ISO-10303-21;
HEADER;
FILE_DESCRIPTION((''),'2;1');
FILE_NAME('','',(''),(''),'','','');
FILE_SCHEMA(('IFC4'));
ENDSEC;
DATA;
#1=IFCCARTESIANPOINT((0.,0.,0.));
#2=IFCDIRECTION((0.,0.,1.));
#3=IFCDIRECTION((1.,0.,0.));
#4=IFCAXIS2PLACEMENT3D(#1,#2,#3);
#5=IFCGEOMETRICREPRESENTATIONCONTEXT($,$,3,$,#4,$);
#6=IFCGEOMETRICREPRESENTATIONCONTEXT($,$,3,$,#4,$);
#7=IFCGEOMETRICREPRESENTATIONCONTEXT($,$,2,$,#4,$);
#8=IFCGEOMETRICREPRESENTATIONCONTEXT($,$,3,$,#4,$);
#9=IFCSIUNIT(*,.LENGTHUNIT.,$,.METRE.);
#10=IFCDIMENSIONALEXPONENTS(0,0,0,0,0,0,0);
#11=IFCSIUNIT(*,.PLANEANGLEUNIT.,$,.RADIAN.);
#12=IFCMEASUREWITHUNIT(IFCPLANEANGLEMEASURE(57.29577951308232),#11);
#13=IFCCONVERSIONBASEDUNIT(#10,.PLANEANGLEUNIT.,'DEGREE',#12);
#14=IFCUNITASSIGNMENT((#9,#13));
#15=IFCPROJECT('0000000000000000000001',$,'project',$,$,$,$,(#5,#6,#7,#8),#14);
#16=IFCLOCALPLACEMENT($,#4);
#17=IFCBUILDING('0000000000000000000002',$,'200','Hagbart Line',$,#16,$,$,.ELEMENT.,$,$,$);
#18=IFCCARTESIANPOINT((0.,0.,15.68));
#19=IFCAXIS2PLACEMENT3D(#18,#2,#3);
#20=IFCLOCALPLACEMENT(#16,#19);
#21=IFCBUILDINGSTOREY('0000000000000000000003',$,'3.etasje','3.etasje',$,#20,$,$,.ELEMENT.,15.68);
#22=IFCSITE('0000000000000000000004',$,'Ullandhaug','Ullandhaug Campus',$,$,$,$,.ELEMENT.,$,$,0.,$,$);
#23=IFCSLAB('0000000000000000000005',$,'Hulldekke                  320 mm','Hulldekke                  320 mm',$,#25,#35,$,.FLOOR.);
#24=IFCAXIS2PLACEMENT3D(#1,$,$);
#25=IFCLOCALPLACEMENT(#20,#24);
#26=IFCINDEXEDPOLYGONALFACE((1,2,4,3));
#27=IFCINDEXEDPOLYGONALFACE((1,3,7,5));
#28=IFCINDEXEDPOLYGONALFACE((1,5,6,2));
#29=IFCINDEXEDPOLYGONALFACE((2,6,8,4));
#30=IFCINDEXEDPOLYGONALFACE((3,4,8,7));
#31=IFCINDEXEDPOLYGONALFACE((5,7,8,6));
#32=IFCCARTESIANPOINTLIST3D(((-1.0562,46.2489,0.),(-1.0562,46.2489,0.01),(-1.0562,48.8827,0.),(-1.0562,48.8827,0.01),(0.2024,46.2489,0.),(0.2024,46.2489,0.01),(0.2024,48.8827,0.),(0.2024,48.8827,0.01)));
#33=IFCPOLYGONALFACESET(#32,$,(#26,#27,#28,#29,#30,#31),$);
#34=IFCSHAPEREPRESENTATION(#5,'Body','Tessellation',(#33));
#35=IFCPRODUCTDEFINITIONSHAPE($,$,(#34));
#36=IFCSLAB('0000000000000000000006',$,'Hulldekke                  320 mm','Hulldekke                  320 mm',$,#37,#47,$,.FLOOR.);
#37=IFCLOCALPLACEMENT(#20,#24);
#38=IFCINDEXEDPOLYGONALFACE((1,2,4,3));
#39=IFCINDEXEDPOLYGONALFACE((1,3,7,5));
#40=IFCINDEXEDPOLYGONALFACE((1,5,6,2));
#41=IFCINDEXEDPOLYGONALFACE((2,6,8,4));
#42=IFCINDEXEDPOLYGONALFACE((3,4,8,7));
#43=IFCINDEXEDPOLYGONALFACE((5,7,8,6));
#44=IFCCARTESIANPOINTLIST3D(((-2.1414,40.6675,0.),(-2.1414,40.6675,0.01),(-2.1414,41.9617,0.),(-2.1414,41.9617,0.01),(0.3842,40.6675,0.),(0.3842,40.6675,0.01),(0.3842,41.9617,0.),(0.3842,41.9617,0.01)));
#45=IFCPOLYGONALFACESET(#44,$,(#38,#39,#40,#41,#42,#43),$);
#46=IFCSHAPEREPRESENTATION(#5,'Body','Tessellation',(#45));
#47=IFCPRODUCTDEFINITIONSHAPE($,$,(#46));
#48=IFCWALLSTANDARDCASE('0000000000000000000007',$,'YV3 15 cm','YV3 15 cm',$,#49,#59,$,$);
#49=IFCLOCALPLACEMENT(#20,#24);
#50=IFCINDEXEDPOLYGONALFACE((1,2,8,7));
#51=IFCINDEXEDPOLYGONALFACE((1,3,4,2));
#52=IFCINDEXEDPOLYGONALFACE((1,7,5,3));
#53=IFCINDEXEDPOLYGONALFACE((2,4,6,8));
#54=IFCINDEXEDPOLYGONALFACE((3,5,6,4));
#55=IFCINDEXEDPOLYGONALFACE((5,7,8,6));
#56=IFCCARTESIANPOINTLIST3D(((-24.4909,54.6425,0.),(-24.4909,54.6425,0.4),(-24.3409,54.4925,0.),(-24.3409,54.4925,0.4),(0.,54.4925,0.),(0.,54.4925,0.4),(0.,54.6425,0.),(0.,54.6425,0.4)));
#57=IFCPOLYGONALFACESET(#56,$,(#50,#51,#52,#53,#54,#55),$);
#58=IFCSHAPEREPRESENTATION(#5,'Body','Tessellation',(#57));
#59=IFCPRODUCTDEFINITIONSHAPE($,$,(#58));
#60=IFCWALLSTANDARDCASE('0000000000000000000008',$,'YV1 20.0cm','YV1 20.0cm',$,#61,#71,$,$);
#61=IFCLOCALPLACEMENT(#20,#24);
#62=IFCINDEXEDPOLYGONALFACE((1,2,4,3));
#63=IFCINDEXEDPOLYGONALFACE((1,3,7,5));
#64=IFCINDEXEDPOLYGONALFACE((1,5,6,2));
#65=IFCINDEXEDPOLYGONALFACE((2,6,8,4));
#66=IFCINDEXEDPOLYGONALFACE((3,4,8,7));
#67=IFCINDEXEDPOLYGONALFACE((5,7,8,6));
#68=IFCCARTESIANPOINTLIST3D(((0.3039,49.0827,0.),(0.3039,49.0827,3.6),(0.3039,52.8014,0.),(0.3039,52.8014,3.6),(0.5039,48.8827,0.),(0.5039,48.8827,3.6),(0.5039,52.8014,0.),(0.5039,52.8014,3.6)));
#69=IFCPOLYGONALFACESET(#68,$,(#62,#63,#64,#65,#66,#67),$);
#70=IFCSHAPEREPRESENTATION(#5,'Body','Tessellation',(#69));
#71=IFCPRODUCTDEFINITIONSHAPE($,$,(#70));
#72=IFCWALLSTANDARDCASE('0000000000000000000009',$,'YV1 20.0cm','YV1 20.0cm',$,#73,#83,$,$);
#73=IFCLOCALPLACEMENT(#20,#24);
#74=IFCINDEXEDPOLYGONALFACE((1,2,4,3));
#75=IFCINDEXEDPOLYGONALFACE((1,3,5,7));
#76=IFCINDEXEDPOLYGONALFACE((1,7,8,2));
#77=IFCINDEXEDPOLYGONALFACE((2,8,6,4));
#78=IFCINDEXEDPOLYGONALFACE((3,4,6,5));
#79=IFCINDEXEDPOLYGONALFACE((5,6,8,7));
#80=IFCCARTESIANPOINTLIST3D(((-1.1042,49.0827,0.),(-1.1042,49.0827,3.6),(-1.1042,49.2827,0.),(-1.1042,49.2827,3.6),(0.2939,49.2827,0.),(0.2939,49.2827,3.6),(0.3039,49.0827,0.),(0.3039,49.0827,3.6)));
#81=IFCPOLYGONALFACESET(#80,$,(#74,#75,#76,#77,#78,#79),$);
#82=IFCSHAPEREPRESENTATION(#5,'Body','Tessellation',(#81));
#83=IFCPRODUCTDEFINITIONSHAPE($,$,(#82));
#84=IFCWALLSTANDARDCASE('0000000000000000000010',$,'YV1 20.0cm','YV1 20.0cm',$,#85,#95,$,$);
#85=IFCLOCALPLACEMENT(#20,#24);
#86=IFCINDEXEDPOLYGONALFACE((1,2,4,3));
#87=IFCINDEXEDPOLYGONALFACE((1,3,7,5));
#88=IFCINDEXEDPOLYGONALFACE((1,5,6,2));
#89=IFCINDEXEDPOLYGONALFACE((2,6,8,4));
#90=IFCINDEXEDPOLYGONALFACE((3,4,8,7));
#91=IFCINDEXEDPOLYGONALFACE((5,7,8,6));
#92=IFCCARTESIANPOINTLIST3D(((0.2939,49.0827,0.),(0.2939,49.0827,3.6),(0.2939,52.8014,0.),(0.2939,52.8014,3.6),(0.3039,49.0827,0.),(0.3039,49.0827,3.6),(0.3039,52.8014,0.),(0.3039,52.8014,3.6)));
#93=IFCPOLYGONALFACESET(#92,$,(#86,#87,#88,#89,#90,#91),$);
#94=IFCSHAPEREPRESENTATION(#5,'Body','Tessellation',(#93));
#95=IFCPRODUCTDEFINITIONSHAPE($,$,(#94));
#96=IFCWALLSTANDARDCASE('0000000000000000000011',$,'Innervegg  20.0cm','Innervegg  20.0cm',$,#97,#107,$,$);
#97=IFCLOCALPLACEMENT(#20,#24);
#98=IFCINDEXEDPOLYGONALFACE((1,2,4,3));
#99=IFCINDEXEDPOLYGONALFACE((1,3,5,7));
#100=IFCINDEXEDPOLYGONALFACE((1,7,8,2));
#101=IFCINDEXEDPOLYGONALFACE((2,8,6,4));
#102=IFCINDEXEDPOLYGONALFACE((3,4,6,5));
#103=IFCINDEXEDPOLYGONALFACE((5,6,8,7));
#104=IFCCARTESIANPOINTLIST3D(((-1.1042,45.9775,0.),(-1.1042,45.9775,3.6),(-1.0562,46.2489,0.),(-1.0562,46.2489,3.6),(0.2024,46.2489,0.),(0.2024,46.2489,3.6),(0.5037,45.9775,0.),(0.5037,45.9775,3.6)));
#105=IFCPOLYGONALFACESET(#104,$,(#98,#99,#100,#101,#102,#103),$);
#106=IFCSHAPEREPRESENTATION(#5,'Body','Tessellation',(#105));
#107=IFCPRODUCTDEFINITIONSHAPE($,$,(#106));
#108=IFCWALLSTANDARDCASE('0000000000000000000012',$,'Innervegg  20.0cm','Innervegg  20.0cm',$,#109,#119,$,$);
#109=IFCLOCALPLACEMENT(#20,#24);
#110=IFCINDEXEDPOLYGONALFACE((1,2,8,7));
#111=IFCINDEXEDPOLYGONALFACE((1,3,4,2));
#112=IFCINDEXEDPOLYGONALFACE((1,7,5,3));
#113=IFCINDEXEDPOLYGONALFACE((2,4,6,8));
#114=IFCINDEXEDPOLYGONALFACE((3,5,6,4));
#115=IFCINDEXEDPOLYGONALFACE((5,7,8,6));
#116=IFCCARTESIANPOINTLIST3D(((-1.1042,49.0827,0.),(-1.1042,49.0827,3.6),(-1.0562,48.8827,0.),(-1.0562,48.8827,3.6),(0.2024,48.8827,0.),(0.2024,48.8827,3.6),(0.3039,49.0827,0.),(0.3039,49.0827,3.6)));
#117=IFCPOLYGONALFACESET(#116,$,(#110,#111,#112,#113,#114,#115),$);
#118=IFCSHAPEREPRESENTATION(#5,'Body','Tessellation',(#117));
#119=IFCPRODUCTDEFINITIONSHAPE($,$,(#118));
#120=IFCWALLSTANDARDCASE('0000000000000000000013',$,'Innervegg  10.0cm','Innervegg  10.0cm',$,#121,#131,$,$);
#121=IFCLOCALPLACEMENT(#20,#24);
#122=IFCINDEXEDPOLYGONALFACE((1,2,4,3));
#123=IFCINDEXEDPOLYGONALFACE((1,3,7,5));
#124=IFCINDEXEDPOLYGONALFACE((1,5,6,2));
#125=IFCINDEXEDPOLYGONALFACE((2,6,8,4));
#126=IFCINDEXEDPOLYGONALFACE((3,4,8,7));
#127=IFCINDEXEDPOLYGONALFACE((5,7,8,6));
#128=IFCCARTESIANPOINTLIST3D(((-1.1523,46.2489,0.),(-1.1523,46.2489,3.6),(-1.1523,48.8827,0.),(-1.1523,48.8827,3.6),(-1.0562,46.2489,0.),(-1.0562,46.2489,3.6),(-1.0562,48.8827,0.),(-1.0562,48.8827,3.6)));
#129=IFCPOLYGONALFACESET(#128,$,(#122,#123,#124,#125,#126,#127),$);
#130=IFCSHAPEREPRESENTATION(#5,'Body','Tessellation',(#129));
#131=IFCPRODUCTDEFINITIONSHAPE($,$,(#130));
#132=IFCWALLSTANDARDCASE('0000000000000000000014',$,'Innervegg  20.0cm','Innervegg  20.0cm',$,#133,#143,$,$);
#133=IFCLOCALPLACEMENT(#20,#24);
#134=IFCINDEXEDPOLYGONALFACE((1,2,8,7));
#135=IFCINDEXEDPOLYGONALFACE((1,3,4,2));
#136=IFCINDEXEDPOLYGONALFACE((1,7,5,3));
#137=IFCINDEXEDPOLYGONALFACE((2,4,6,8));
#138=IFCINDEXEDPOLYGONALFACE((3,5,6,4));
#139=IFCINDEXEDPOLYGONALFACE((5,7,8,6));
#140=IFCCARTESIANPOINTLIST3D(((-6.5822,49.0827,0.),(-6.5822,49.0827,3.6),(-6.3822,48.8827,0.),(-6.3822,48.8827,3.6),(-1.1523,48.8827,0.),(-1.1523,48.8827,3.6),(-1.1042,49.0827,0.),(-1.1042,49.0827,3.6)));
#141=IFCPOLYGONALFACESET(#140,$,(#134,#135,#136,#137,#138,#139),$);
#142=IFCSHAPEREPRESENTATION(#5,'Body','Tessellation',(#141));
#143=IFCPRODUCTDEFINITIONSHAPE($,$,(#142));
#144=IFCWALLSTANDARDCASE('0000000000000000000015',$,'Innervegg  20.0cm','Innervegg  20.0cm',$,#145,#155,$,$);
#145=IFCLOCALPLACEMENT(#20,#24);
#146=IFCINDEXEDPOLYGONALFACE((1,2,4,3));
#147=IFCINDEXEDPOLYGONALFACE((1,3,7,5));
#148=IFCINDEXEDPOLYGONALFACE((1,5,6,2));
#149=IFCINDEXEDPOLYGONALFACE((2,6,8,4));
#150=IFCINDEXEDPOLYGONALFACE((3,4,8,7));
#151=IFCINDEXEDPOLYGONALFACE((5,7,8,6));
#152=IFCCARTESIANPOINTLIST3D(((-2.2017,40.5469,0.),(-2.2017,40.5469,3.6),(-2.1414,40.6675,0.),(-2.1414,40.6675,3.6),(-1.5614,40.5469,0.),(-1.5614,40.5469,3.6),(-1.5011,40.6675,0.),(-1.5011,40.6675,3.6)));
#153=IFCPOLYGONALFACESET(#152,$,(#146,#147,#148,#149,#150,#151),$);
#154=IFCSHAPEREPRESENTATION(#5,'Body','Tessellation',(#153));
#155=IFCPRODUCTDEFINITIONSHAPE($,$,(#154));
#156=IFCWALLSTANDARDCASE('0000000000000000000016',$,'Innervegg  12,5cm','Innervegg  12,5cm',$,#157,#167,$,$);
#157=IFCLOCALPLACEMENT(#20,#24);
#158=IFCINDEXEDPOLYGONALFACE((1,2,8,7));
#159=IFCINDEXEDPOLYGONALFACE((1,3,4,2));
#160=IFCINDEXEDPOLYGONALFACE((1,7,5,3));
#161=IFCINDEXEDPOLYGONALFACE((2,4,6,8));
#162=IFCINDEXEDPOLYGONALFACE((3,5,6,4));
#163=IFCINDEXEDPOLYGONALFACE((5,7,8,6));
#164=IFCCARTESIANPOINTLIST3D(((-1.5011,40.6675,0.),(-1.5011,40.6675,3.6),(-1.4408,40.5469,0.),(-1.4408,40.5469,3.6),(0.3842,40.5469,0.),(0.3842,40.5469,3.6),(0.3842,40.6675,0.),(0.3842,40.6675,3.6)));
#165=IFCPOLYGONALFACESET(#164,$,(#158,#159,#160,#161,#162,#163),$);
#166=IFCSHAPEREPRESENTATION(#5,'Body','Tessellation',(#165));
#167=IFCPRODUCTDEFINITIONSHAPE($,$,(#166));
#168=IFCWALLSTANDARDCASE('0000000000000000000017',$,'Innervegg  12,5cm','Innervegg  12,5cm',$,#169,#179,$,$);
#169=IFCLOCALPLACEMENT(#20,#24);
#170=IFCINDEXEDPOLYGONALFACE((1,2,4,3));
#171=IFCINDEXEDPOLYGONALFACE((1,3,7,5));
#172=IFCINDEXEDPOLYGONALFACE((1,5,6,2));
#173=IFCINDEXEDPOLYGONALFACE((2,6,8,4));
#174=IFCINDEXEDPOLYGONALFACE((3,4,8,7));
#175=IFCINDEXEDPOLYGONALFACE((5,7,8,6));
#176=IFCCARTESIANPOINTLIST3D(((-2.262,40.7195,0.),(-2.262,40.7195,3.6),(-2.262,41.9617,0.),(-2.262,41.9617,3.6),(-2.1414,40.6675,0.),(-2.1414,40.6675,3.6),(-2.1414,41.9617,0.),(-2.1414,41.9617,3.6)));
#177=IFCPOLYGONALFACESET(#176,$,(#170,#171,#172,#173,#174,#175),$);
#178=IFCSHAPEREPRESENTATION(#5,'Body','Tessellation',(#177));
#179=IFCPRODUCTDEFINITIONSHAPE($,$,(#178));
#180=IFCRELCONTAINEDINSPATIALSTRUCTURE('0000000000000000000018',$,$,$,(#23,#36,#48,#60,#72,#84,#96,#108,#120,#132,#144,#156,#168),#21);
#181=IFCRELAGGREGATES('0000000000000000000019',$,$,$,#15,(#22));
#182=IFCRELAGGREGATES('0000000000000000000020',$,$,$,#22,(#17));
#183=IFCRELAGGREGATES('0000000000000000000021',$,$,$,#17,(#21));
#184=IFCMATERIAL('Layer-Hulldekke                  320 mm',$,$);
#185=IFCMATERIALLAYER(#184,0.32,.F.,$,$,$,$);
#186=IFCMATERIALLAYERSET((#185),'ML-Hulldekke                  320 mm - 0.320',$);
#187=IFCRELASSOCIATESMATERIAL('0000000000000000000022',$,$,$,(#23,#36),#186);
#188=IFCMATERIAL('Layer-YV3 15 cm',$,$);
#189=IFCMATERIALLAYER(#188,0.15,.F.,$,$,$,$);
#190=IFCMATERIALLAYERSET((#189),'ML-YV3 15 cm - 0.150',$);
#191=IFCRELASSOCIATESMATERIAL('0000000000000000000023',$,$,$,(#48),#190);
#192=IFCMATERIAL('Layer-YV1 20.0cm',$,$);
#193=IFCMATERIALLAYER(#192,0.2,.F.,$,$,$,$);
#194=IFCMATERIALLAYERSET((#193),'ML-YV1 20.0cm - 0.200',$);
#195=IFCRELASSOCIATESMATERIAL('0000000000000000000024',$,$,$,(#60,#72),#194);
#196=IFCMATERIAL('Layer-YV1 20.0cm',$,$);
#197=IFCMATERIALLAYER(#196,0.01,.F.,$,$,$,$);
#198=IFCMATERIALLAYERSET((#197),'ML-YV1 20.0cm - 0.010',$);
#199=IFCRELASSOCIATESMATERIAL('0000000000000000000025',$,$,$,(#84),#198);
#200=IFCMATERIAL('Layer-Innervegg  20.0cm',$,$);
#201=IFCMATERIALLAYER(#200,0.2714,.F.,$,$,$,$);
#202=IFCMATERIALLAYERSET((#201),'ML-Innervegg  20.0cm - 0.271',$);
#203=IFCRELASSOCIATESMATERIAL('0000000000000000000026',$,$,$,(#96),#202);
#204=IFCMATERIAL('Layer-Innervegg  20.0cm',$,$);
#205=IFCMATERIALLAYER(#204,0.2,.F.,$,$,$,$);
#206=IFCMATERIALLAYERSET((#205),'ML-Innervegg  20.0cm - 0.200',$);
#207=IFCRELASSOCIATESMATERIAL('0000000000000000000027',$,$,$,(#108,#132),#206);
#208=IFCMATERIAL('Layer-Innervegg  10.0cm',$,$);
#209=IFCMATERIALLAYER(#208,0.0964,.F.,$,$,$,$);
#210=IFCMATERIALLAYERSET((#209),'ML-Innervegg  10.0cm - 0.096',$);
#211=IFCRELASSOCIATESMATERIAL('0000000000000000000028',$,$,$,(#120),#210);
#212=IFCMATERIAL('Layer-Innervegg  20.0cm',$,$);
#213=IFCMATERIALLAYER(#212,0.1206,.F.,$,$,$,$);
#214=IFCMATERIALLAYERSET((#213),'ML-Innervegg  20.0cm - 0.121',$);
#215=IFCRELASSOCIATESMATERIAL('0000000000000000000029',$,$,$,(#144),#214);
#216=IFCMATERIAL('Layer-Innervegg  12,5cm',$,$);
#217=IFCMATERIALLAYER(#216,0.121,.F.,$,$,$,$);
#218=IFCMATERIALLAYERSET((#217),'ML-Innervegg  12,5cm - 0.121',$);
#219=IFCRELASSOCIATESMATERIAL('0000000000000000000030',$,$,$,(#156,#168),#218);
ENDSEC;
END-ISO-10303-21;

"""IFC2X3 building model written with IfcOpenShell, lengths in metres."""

from ifc_helpers import new_model, entity, si_unit, converted_unit, frame, origin_with_axes, place, context, project, spatial, polyline, outline, extrude, material, layer, layer_set, layer_usage, element, save


model = new_model("IFC2X3")

# Units and contexts
context_of_model_1 = context(None, 3, world=origin_with_axes())
context_of_model_2 = context(None, 3, world=origin_with_axes())
context_of_model_3 = context(None, 2, world=origin_with_axes())
context_of_model_4 = context(None, 3, world=origin_with_axes())
ifc_project = project(units=[si_unit("LENGTHUNIT", "METRE"), converted_unit("PLANEANGLEUNIT", "DEGREE", entity("IfcPlaneAngleMeasure", 57.29577951308232), si_unit("PLANEANGLEUNIT", "RADIAN"), dimensions=[0, 0, 0, 0, 0, 0, 0])], contexts=[context_of_model_1, context_of_model_2, context_of_model_3, context_of_model_4])

# Site, building, storey
site = spatial("IfcSite", under=ifc_project, Name="Ullandhaug", Description="Ullandhaug Campus", CompositionType="ELEMENT", RefElevation=0.0)
building_placement = place(None, origin_with_axes())
building = spatial("IfcBuilding", under=site, at=building_placement, Name="200", Description="Hagbart Line", CompositionType="ELEMENT")
storey_placement = place(building_placement, frame((0.0, 0.0, 15.68), z_axis=(0.0, 0.0, 1.0), x_axis=(1.0, 0.0, 0.0)))
storey = spatial("IfcBuildingStorey", under=building, at=storey_placement, Name="3.etasje", Description="3.etasje", CompositionType="ELEMENT", Elevation=15.68)

# Slabs
ifc_material_1 = material(Name="Layer-Hulldekke                  320 mm")
ifc_layer_1 = layer(ifc_material_1, 0.32, ventilated=False)
ifc_layer_set_1 = layer_set([ifc_layer_1], Name="ML-Hulldekke                  320 mm - 0.320")
ifc_layer_usage_1 = layer_usage(ifc_layer_set_1, "AXIS2", "POSITIVE", 0.0)
slab_1_placement = place(storey_placement, frame((-1.0562, 46.2489, 0.0), z_axis=(0.0, 0.0, 1.0), x_axis=(1.0, 0.0, 0.0)))
element("IfcSlab", 1, at=slab_1_placement, inside=storey, material=ifc_layer_usage_1, Name="Hulldekke                  320 mm", Description="Hulldekke                  320 mm", PredefinedType="FLOOR", context=context_of_model_1, shape_type="SweptSolid", body=[
    extrude(outline(polyline([(0.0, 0.0), (1.2586, 0.0), (1.2586, 2.6338), (0.0, 2.6338), (0.0, 0.0)])), origin_with_axes(), (0.0, 0.0, 1.0), 0.01),
])
slab_2_placement = place(storey_placement, frame((-2.1414, 40.6675, 0.0), z_axis=(0.0, 0.0, 1.0), x_axis=(1.0, 0.0, 0.0)))
element("IfcSlab", 2, at=slab_2_placement, inside=storey, material=ifc_layer_usage_1, Name="Hulldekke                  320 mm", Description="Hulldekke                  320 mm", PredefinedType="FLOOR", context=context_of_model_1, shape_type="SweptSolid", body=[
    extrude(outline(polyline([(0.0, 0.0), (2.5256, 0.0), (2.5256, 1.2942), (0.0, 1.2942), (0.0, 0.0)])), origin_with_axes(), (0.0, 0.0, 1.0), 0.01),
])

# Walls
ifc_material_2 = material(Name="Layer-YV3 15 cm")
ifc_layer_2 = layer(ifc_material_2, 0.15, ventilated=False)
ifc_layer_set_2 = layer_set([ifc_layer_2], Name="ML-YV3 15 cm - 0.150")
ifc_layer_usage_2 = layer_usage(ifc_layer_set_2, "AXIS2", "POSITIVE", 0.0)
wall_1_placement = place(storey_placement, frame((0.0, 54.6425, 0.0), z_axis=(0.0, 0.0, 1.0), x_axis=(-1.0, 0.0, 0.0)))
element("IfcWallStandardCase", 3, at=wall_1_placement, inside=storey, material=ifc_layer_usage_2, Name="YV3 15 cm", Description="YV3 15 cm", context=context_of_model_1, shape_type="SweptSolid", body=[
    extrude(outline(polyline([(0.0, 0.0), (24.4909, 0.0), (24.3409, 0.15), (0.0, 0.15), (0.0, 0.0)])), frame((0.0, 0.0, 0.0), z_axis=(0.0, 0.0, 1.0), x_axis=(1.0, 0.0, 0.0)), (0.0, 0.0, 1.0), 0.4),
])
ifc_material_3 = material(Name="Layer-YV1 20.0cm")
ifc_layer_3 = layer(ifc_material_3, 0.2, ventilated=False)
ifc_layer_set_3 = layer_set([ifc_layer_3], Name="ML-YV1 20.0cm - 0.200")
ifc_layer_usage_3 = layer_usage(ifc_layer_set_3, "AXIS2", "POSITIVE", 0.0)
wall_2_placement = place(storey_placement, frame((0.3039, 52.8014, 0.0), z_axis=(0.0, 0.0, 1.0), x_axis=(0.0, -1.0, 0.0)))
element("IfcWallStandardCase", 4, at=wall_2_placement, inside=storey, material=ifc_layer_usage_3, Name="YV1 20.0cm", Description="YV1 20.0cm", context=context_of_model_1, shape_type="SweptSolid", body=[
    extrude(outline(polyline([(0.0, 0.0), (3.7187, 0.0), (3.9187, 0.2), (0.0, 0.2), (0.0, 0.0)])), frame((0.0, 0.0, 0.0), z_axis=(0.0, 0.0, 1.0), x_axis=(1.0, 0.0, 0.0)), (0.0, 0.0, 1.0), 3.6),
])
wall_3_placement = place(storey_placement, frame((-1.1042, 49.0827, 0.0), z_axis=(0.0, 0.0, 1.0), x_axis=(1.0, 0.0, 0.0)))
element("IfcWallStandardCase", 5, at=wall_3_placement, inside=storey, material=ifc_layer_usage_3, Name="YV1 20.0cm", Description="YV1 20.0cm", context=context_of_model_1, shape_type="SweptSolid", body=[
    extrude(outline(polyline([(0.0, 0.0), (1.4081, 0.0), (1.3981, 0.2), (0.0, 0.2), (0.0, 0.0)])), origin_with_axes(), (0.0, 0.0, 1.0), 3.6),
])
ifc_material_4 = material(Name="Layer-YV1 20.0cm")
ifc_layer_4 = layer(ifc_material_4, 0.01, ventilated=False)
ifc_layer_set_4 = layer_set([ifc_layer_4], Name="ML-YV1 20.0cm - 0.010")
ifc_layer_usage_4 = layer_usage(ifc_layer_set_4, "AXIS2", "POSITIVE", 0.0)
wall_4_placement = place(storey_placement, frame((0.3039, 49.0827, 0.0), z_axis=(0.0, 0.0, 1.0), x_axis=(0.0, 1.0, 0.0)))
element("IfcWallStandardCase", 6, at=wall_4_placement, inside=storey, material=ifc_layer_usage_4, Name="YV1 20.0cm", Description="YV1 20.0cm", context=context_of_model_1, shape_type="SweptSolid", body=[
    extrude(outline(polyline([(0.0, 0.0), (3.7187, 0.0), (3.7187, 0.01), (0.0, 0.01), (0.0, 0.0)])), frame((0.0, 0.0, 0.0), z_axis=(0.0, 0.0, 1.0), x_axis=(1.0, 0.0, 0.0)), (0.0, 0.0, 1.0), 3.6),
])
ifc_material_5 = material(Name="Layer-Innervegg  20.0cm")
ifc_layer_5 = layer(ifc_material_5, 0.2714, ventilated=False)
ifc_layer_set_5 = layer_set([ifc_layer_5], Name="ML-Innervegg  20.0cm - 0.271")
ifc_layer_usage_5 = layer_usage(ifc_layer_set_5, "AXIS2", "POSITIVE", 0.0)
wall_5_placement = place(storey_placement, frame((-1.1042, 45.9775, 0.0), z_axis=(0.0, 0.0, 1.0), x_axis=(1.0, 0.0, 0.0)))
element("IfcWallStandardCase", 7, at=wall_5_placement, inside=storey, material=ifc_layer_usage_5, Name="Innervegg  20.0cm", Description="Innervegg  20.0cm", context=context_of_model_1, shape_type="SweptSolid", body=[
    extrude(outline(polyline([(0.0, 0.0), (1.6079, 0.0), (1.3066, 0.2713), (0.0481, 0.2713), (0.0, 0.0)])), origin_with_axes(), (0.0, 0.0, 1.0), 3.6),
])
ifc_material_6 = material(Name="Layer-Innervegg  20.0cm")
ifc_layer_6 = layer(ifc_material_6, 0.2, ventilated=False)
ifc_layer_set_6 = layer_set([ifc_layer_6], Name="ML-Innervegg  20.0cm - 0.200")
ifc_layer_usage_6 = layer_usage(ifc_layer_set_6, "AXIS2", "POSITIVE", 0.0)
wall_6_placement = place(storey_placement, frame((0.3039, 49.0827, 0.0), z_axis=(0.0, 0.0, 1.0), x_axis=(-1.0, 0.0, 0.0)))
element("IfcWallStandardCase", 8, at=wall_6_placement, inside=storey, material=ifc_layer_usage_6, Name="Innervegg  20.0cm", Description="Innervegg  20.0cm", context=context_of_model_1, shape_type="SweptSolid", body=[
    extrude(outline(polyline([(0.0, 0.0), (1.4081, 0.0), (1.3601, 0.2), (0.1015, 0.2), (0.0, 0.0)])), frame((0.0, 0.0, 0.0), z_axis=(0.0, 0.0, 1.0), x_axis=(1.0, 0.0, 0.0)), (0.0, 0.0, 1.0), 3.6),
])
ifc_material_7 = material(Name="Layer-Innervegg  10.0cm")
ifc_layer_7 = layer(ifc_material_7, 0.0964, ventilated=False)
ifc_layer_set_7 = layer_set([ifc_layer_7], Name="ML-Innervegg  10.0cm - 0.096")
ifc_layer_usage_7 = layer_usage(ifc_layer_set_7, "AXIS2", "POSITIVE", 0.0)
wall_7_placement = place(storey_placement, frame((-1.1523, 48.8827, 0.0), z_axis=(0.0, 0.0, 1.0), x_axis=(0.0, -1.0, 0.0)))
element("IfcWallStandardCase", 9, at=wall_7_placement, inside=storey, material=ifc_layer_usage_7, Name="Innervegg  10.0cm", Description="Innervegg  10.0cm", context=context_of_model_1, shape_type="SweptSolid", body=[
    extrude(outline(polyline([(0.0, 0.0), (2.6338, 0.0), (2.6338, 0.0961), (0.0, 0.0961), (0.0, 0.0)])), frame((0.0, 0.0, 0.0), z_axis=(0.0, 0.0, 1.0), x_axis=(1.0, 0.0, 0.0)), (0.0, 0.0, 1.0), 3.6),
])
wall_8_placement = place(storey_placement, frame((-1.1042, 49.0827, 0.0), z_axis=(0.0, 0.0, 1.0), x_axis=(-1.0, 0.0, 0.0)))
element("IfcWallStandardCase", 10, at=wall_8_placement, inside=storey, material=ifc_layer_usage_6, Name="Innervegg  20.0cm", Description="Innervegg  20.0cm", context=context_of_model_1, shape_type="SweptSolid", body=[
    extrude(outline(polyline([(0.0, 0.0), (5.478, 0.0), (5.278, 0.2), (0.0481, 0.2), (0.0, 0.0)])), frame((0.0, 0.0, 0.0), z_axis=(0.0, 0.0, 1.0), x_axis=(1.0, 0.0, 0.0)), (0.0, 0.0, 1.0), 3.6),
])
ifc_material_8 = material(Name="Layer-Innervegg  20.0cm")
ifc_layer_8 = layer(ifc_material_8, 0.1206, ventilated=False)
ifc_layer_set_8 = layer_set([ifc_layer_8], Name="ML-Innervegg  20.0cm - 0.121")
ifc_layer_usage_8 = layer_usage(ifc_layer_set_8, "AXIS2", "POSITIVE", 0.0)
wall_9_placement = place(storey_placement, frame((-2.2017, 40.5469, 0.0), z_axis=(0.0, 0.0, 1.0), x_axis=(1.0, 0.0, 0.0)))
element("IfcWallStandardCase", 11, at=wall_9_placement, inside=storey, material=ifc_layer_usage_8, Name="Innervegg  20.0cm", Description="Innervegg  20.0cm", context=context_of_model_1, shape_type="SweptSolid", body=[
    extrude(outline(polyline([(0.0, 0.0), (0.6402, 0.0), (0.7005, 0.1206), (0.0603, 0.1206), (0.0, 0.0)])), origin_with_axes(), (0.0, 0.0, 1.0), 3.6),
])
ifc_material_9 = material(Name="Layer-Innervegg  12,5cm")
ifc_layer_9 = layer(ifc_material_9, 0.121, ventilated=False)
ifc_layer_set_9 = layer_set([ifc_layer_9], Name="ML-Innervegg  12,5cm - 0.121")
ifc_layer_usage_9 = layer_usage(ifc_layer_set_9, "AXIS2", "POSITIVE", 0.0)
wall_10_placement = place(storey_placement, frame((-1.4408, 40.5469, 0.0), z_axis=(0.0, 0.0, 1.0), x_axis=(1.0, 0.0, 0.0)))
element("IfcWallStandardCase", 12, at=wall_10_placement, inside=storey, material=ifc_layer_usage_9, Name="Innervegg  12,5cm", Description="Innervegg  12,5cm", context=context_of_model_1, shape_type="SweptSolid", body=[
    extrude(outline(polyline([(0.0, 0.0), (1.825, 0.0), (1.825, 0.1206), (-0.0603, 0.1206), (0.0, 0.0)])), origin_with_axes(), (0.0, 0.0, 1.0), 3.6),
])
wall_11_placement = place(storey_placement, frame((-2.262, 41.9617, 0.0), z_axis=(0.0, 0.0, 1.0), x_axis=(0.0, -1.0, 0.0)))
element("IfcWallStandardCase", 13, at=wall_11_placement, inside=storey, material=ifc_layer_usage_9, Name="Innervegg  12,5cm", Description="Innervegg  12,5cm", context=context_of_model_1, shape_type="SweptSolid", body=[
    extrude(outline(polyline([(0.0, 0.0), (1.2422, 0.0), (1.2942, 0.1206), (0.0, 0.1206), (0.0, 0.0)])), frame((0.0, 0.0, 0.0), z_axis=(0.0, 0.0, 1.0), x_axis=(1.0, 0.0, 0.0)), (0.0, 0.0, 1.0), 3.6),
])

save(model, "model.ifc")
